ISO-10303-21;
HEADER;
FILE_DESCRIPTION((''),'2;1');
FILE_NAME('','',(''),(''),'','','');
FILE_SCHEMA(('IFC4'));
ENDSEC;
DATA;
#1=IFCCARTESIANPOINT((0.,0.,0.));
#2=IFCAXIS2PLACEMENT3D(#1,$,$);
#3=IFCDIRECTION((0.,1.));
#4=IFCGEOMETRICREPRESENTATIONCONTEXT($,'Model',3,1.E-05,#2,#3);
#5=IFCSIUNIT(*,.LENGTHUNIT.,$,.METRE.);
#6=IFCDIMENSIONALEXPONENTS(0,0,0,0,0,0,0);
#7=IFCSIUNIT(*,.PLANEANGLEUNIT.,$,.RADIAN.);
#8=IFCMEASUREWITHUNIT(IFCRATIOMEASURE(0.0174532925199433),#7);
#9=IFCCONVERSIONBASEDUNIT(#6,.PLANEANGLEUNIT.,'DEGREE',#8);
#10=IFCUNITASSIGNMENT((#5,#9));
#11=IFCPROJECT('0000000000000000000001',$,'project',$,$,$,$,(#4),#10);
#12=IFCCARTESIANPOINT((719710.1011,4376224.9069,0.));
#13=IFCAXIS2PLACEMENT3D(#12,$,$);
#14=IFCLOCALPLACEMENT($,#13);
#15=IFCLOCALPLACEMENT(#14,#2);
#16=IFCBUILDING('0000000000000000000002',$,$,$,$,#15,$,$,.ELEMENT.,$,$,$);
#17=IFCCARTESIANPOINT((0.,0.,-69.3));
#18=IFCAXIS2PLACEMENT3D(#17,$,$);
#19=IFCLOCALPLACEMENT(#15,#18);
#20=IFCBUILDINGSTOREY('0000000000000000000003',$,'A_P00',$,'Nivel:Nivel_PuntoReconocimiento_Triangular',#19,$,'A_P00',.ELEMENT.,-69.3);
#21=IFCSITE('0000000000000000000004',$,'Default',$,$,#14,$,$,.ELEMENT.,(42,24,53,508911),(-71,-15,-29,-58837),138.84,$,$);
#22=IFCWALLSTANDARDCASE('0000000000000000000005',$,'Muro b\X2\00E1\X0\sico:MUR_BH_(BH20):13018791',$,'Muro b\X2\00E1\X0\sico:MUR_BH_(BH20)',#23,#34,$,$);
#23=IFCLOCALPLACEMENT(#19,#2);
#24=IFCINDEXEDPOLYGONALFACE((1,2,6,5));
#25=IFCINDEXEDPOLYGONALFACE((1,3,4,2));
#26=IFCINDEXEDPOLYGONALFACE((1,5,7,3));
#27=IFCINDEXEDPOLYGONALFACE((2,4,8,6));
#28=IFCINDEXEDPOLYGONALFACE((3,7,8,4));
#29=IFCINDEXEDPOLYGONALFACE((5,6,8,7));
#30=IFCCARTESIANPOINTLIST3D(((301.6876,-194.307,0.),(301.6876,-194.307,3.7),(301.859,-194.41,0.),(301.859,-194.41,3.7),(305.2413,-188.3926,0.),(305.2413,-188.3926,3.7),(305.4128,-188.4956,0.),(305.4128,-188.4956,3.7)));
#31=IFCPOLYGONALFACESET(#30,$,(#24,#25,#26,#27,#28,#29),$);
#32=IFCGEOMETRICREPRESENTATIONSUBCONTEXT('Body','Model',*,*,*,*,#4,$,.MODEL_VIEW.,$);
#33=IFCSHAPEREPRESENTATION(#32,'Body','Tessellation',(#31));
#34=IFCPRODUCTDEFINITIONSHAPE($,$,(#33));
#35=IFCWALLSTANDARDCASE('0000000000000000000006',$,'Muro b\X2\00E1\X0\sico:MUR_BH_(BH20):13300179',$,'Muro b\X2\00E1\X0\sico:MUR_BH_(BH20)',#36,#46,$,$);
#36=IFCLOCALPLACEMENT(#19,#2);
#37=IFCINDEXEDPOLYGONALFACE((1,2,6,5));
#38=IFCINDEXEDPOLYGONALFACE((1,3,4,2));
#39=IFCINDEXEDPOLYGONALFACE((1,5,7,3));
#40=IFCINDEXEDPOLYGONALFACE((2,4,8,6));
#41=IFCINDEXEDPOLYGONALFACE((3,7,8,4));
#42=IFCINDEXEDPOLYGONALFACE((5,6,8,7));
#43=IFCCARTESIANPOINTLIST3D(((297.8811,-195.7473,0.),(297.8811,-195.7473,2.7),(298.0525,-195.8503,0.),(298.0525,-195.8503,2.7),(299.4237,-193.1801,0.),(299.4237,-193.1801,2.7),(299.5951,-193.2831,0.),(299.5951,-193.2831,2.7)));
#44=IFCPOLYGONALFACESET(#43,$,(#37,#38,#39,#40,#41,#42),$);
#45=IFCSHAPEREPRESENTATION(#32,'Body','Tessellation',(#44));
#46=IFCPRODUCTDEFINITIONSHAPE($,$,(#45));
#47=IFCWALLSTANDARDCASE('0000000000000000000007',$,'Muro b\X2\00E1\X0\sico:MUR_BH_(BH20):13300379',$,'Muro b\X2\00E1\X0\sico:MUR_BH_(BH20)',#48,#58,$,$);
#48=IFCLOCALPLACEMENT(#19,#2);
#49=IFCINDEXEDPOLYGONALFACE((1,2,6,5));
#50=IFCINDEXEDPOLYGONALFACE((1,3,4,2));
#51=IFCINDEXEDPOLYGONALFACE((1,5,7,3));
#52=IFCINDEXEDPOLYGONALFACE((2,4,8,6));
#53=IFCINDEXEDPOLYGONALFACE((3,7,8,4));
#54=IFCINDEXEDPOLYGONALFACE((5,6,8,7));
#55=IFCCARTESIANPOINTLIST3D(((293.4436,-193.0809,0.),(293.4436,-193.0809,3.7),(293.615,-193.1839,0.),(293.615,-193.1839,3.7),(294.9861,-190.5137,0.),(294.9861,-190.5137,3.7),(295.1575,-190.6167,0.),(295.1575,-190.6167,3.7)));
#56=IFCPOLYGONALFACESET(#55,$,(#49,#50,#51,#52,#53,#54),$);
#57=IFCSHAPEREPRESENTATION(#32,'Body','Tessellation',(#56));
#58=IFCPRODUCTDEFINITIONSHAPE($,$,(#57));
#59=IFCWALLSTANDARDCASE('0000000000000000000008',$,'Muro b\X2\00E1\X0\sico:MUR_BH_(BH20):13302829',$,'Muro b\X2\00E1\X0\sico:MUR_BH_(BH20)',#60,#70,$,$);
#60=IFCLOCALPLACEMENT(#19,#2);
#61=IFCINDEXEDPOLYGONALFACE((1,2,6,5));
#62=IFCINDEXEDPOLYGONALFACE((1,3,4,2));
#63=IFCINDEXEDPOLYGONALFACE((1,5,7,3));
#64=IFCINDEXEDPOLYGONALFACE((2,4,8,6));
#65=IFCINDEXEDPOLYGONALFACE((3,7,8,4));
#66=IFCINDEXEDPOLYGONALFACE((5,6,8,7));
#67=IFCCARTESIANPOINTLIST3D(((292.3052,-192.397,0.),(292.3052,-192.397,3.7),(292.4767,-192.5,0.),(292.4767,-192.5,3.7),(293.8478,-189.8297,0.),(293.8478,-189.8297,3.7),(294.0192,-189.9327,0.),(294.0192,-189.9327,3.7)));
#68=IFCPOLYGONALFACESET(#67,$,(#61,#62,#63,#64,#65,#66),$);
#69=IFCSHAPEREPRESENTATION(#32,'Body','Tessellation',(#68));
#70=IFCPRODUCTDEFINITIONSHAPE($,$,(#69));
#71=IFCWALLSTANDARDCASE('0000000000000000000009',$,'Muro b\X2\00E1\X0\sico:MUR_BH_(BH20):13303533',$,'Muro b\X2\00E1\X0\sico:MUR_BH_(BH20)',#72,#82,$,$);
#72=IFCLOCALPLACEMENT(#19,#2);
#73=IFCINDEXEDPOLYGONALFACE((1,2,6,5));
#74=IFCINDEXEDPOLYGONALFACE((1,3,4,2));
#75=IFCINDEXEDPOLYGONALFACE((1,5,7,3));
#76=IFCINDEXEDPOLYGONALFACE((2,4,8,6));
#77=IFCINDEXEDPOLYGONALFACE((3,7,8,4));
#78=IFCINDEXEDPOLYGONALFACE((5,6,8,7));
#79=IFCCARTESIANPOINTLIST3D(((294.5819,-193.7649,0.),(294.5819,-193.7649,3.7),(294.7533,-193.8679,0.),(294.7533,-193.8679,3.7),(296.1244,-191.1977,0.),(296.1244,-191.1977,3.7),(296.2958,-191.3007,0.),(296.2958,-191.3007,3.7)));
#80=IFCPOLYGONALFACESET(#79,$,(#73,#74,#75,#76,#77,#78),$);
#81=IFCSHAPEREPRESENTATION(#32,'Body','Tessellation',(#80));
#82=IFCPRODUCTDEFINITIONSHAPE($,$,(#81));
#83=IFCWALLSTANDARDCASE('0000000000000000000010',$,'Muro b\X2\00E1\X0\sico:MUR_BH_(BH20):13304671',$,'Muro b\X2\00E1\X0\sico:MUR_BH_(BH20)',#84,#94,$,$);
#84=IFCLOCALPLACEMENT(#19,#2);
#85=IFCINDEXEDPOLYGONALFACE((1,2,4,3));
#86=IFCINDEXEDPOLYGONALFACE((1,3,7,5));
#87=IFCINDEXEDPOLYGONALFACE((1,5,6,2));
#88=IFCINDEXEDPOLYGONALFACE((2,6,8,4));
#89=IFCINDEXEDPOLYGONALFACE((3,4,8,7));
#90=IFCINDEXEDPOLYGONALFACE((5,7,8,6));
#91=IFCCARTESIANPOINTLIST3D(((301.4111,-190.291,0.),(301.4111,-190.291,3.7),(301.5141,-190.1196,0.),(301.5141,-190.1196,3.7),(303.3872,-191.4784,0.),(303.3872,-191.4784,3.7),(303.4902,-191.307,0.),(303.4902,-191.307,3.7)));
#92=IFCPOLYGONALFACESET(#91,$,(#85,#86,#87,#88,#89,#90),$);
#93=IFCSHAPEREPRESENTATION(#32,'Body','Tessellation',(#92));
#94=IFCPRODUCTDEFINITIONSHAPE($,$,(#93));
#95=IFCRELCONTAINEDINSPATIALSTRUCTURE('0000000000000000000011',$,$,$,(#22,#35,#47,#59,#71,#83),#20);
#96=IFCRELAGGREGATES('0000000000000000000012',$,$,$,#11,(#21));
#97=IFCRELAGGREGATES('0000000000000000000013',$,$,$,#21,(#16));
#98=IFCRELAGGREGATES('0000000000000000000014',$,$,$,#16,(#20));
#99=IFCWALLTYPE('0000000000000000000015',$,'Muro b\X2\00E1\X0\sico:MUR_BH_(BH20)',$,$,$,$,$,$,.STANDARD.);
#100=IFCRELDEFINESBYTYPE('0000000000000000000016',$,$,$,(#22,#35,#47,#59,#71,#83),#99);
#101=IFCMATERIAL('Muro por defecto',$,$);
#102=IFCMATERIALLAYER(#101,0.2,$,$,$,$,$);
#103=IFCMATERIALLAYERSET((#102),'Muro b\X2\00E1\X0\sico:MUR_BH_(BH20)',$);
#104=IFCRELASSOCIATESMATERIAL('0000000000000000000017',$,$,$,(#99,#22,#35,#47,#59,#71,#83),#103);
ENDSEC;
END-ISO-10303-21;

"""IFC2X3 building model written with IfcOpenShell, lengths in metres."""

from ifc_helpers import new_model, entity, si_unit, converted_unit, direction, frame, frame_2d, origin, place, context, subcontext, project, spatial, rectangle, extrude, material, layer, layer_set, layer_usage, type_object, element, save


model = new_model("IFC2X3")

# Units and contexts
model_context = context("Model", 3, precision=1e-05, world=origin(), true_north=direction((0.0, 1.0)))
body_context = subcontext(model_context, "Body", "Model", "MODEL_VIEW")
ifc_project = project(units=[si_unit("LENGTHUNIT", "METRE"), converted_unit("PLANEANGLEUNIT", "DEGREE", entity("IfcRatioMeasure", 0.0174532925199433), si_unit("PLANEANGLEUNIT", "RADIAN"), dimensions=[0, 0, 0, 0, 0, 0, 0])], contexts=[model_context])

# Site, building, storey
site_placement = place(None, frame((719710.1011, 4376224.9069, 0.0)))
site = spatial("IfcSite", under=ifc_project, at=site_placement, Name="Default", CompositionType="ELEMENT", RefLatitude=(42, 24, 53, 508911), RefLongitude=(-71, -15, -29, -58837), RefElevation=138.84)
building_placement = place(site_placement, origin())
building = spatial("IfcBuilding", under=site, at=building_placement, CompositionType="ELEMENT")
storey_placement = place(building_placement, frame((0.0, 0.0, -69.3)))
storey = spatial("IfcBuildingStorey", under=building, at=storey_placement, Name="A_P00", ObjectType="Nivel:Nivel_PuntoReconocimiento_Triangular", LongName="A_P00", CompositionType="ELEMENT", Elevation=-69.3)

# Shared definitions
ifc_material_1 = material(Name="Muro por defecto")
ifc_layer = layer(ifc_material_1, 0.2)
ifc_layer_set = layer_set([ifc_layer], Name="Muro básico:MUR_BH_(BH20)")
wall_type = type_object("IfcWallType", Name="Muro básico:MUR_BH_(BH20)", PredefinedType="STANDARD", material=ifc_layer_set)

# Walls
ifc_layer_usage_1 = layer_usage(ifc_layer_set, "AXIS2", "POSITIVE", -0.1)
wall_1_placement = place(storey_placement, frame((301.7733, -194.3585, 0.0), z_axis=(0.0, 0.0, 1.0), x_axis=(0.515038, 0.857167, 0.0)))
element("IfcWallStandardCase", 1, at=wall_1_placement, inside=storey, type_object=wall_type, material=ifc_layer_usage_1, Name="Muro básico:MUR_BH_(BH20):13018791", ObjectType="Muro básico:MUR_BH_(BH20)", context=body_context, shape_type="SweptSolid", body=[
    extrude(rectangle(XDim=6.9, YDim=0.2, at=frame_2d((3.45, 0.0), x_axis=(-1.0, 0.0))), origin(), (0.0, 0.0, 1.0), 3.7),
])
ifc_layer_usage_2 = layer_usage(ifc_layer_set, "AXIS2", "NEGATIVE", 0.1)
wall_2_placement = place(storey_placement, frame((299.5094, -193.2316, 0.0), z_axis=(0.0, 0.0, 1.0), x_axis=(-0.515038, -0.857167, 0.0)))
element("IfcWallStandardCase", 2, at=wall_2_placement, inside=storey, type_object=wall_type, material=ifc_layer_usage_2, Name="Muro básico:MUR_BH_(BH20):13300179", ObjectType="Muro básico:MUR_BH_(BH20)", context=body_context, shape_type="SweptSolid", body=[
    extrude(rectangle(XDim=2.995, YDim=0.2, at=frame_2d((1.4975, 0.0), x_axis=(-1.0, 0.0))), origin(), (0.0, 0.0, 1.0), 2.7),
])
ifc_layer_usage_3 = layer_usage(ifc_layer_set, "AXIS2", "NEGATIVE", 0.1)
wall_3_placement = place(storey_placement, frame((295.0718, -190.5652, 0.0), z_axis=(0.0, 0.0, 1.0), x_axis=(-0.515038, -0.857167, 0.0)))
element("IfcWallStandardCase", 3, at=wall_3_placement, inside=storey, type_object=wall_type, material=ifc_layer_usage_3, Name="Muro básico:MUR_BH_(BH20):13300379", ObjectType="Muro básico:MUR_BH_(BH20)", context=body_context, shape_type="SweptSolid", body=[
    extrude(rectangle(XDim=2.995, YDim=0.2, at=frame_2d((1.4975, 0.0), x_axis=(-1.0, 0.0))), origin(), (0.0, 0.0, 1.0), 3.7),
])
ifc_layer_usage_4 = layer_usage(ifc_layer_set, "AXIS2", "NEGATIVE", 0.1)
wall_4_placement = place(storey_placement, frame((293.9335, -189.8812, 0.0), z_axis=(0.0, 0.0, 1.0), x_axis=(-0.515038, -0.857167, 0.0)))
element("IfcWallStandardCase", 4, at=wall_4_placement, inside=storey, type_object=wall_type, material=ifc_layer_usage_4, Name="Muro básico:MUR_BH_(BH20):13302829", ObjectType="Muro básico:MUR_BH_(BH20)", context=body_context, shape_type="SweptSolid", body=[
    extrude(rectangle(XDim=2.995, YDim=0.2, at=frame_2d((1.4975, 0.0), x_axis=(-1.0, 0.0))), origin(), (0.0, 0.0, 1.0), 3.7),
])
ifc_layer_usage_5 = layer_usage(ifc_layer_set, "AXIS2", "NEGATIVE", 0.1)
wall_5_placement = place(storey_placement, frame((296.2101, -191.2492, 0.0), z_axis=(0.0, 0.0, 1.0), x_axis=(-0.515038, -0.857167, 0.0)))
element("IfcWallStandardCase", 5, at=wall_5_placement, inside=storey, type_object=wall_type, material=ifc_layer_usage_5, Name="Muro básico:MUR_BH_(BH20):13303533", ObjectType="Muro básico:MUR_BH_(BH20)", context=body_context, shape_type="SweptSolid", body=[
    extrude(rectangle(XDim=2.995, YDim=0.2, at=frame_2d((1.4975, 0.0), x_axis=(-1.0, 0.0))), origin(), (0.0, 0.0, 1.0), 3.7),
])
ifc_layer_usage_6 = layer_usage(ifc_layer_set, "AXIS2", "NEGATIVE", 0.1)
wall_6_placement = place(storey_placement, frame((303.4387, -191.3927, 0.0), z_axis=(0.0, 0.0, 1.0), x_axis=(-0.857167, 0.515038, 0.0)))
element("IfcWallStandardCase", 6, at=wall_6_placement, inside=storey, type_object=wall_type, material=ifc_layer_usage_6, Name="Muro básico:MUR_BH_(BH20):13304671", ObjectType="Muro básico:MUR_BH_(BH20)", context=body_context, shape_type="SweptSolid", body=[
    extrude(rectangle(XDim=2.3054, YDim=0.2, at=frame_2d((1.1527, 0.0), x_axis=(-1.0, 0.0))), origin(), (0.0, 0.0, 1.0), 3.7),
])

save(model, "model.ifc")
